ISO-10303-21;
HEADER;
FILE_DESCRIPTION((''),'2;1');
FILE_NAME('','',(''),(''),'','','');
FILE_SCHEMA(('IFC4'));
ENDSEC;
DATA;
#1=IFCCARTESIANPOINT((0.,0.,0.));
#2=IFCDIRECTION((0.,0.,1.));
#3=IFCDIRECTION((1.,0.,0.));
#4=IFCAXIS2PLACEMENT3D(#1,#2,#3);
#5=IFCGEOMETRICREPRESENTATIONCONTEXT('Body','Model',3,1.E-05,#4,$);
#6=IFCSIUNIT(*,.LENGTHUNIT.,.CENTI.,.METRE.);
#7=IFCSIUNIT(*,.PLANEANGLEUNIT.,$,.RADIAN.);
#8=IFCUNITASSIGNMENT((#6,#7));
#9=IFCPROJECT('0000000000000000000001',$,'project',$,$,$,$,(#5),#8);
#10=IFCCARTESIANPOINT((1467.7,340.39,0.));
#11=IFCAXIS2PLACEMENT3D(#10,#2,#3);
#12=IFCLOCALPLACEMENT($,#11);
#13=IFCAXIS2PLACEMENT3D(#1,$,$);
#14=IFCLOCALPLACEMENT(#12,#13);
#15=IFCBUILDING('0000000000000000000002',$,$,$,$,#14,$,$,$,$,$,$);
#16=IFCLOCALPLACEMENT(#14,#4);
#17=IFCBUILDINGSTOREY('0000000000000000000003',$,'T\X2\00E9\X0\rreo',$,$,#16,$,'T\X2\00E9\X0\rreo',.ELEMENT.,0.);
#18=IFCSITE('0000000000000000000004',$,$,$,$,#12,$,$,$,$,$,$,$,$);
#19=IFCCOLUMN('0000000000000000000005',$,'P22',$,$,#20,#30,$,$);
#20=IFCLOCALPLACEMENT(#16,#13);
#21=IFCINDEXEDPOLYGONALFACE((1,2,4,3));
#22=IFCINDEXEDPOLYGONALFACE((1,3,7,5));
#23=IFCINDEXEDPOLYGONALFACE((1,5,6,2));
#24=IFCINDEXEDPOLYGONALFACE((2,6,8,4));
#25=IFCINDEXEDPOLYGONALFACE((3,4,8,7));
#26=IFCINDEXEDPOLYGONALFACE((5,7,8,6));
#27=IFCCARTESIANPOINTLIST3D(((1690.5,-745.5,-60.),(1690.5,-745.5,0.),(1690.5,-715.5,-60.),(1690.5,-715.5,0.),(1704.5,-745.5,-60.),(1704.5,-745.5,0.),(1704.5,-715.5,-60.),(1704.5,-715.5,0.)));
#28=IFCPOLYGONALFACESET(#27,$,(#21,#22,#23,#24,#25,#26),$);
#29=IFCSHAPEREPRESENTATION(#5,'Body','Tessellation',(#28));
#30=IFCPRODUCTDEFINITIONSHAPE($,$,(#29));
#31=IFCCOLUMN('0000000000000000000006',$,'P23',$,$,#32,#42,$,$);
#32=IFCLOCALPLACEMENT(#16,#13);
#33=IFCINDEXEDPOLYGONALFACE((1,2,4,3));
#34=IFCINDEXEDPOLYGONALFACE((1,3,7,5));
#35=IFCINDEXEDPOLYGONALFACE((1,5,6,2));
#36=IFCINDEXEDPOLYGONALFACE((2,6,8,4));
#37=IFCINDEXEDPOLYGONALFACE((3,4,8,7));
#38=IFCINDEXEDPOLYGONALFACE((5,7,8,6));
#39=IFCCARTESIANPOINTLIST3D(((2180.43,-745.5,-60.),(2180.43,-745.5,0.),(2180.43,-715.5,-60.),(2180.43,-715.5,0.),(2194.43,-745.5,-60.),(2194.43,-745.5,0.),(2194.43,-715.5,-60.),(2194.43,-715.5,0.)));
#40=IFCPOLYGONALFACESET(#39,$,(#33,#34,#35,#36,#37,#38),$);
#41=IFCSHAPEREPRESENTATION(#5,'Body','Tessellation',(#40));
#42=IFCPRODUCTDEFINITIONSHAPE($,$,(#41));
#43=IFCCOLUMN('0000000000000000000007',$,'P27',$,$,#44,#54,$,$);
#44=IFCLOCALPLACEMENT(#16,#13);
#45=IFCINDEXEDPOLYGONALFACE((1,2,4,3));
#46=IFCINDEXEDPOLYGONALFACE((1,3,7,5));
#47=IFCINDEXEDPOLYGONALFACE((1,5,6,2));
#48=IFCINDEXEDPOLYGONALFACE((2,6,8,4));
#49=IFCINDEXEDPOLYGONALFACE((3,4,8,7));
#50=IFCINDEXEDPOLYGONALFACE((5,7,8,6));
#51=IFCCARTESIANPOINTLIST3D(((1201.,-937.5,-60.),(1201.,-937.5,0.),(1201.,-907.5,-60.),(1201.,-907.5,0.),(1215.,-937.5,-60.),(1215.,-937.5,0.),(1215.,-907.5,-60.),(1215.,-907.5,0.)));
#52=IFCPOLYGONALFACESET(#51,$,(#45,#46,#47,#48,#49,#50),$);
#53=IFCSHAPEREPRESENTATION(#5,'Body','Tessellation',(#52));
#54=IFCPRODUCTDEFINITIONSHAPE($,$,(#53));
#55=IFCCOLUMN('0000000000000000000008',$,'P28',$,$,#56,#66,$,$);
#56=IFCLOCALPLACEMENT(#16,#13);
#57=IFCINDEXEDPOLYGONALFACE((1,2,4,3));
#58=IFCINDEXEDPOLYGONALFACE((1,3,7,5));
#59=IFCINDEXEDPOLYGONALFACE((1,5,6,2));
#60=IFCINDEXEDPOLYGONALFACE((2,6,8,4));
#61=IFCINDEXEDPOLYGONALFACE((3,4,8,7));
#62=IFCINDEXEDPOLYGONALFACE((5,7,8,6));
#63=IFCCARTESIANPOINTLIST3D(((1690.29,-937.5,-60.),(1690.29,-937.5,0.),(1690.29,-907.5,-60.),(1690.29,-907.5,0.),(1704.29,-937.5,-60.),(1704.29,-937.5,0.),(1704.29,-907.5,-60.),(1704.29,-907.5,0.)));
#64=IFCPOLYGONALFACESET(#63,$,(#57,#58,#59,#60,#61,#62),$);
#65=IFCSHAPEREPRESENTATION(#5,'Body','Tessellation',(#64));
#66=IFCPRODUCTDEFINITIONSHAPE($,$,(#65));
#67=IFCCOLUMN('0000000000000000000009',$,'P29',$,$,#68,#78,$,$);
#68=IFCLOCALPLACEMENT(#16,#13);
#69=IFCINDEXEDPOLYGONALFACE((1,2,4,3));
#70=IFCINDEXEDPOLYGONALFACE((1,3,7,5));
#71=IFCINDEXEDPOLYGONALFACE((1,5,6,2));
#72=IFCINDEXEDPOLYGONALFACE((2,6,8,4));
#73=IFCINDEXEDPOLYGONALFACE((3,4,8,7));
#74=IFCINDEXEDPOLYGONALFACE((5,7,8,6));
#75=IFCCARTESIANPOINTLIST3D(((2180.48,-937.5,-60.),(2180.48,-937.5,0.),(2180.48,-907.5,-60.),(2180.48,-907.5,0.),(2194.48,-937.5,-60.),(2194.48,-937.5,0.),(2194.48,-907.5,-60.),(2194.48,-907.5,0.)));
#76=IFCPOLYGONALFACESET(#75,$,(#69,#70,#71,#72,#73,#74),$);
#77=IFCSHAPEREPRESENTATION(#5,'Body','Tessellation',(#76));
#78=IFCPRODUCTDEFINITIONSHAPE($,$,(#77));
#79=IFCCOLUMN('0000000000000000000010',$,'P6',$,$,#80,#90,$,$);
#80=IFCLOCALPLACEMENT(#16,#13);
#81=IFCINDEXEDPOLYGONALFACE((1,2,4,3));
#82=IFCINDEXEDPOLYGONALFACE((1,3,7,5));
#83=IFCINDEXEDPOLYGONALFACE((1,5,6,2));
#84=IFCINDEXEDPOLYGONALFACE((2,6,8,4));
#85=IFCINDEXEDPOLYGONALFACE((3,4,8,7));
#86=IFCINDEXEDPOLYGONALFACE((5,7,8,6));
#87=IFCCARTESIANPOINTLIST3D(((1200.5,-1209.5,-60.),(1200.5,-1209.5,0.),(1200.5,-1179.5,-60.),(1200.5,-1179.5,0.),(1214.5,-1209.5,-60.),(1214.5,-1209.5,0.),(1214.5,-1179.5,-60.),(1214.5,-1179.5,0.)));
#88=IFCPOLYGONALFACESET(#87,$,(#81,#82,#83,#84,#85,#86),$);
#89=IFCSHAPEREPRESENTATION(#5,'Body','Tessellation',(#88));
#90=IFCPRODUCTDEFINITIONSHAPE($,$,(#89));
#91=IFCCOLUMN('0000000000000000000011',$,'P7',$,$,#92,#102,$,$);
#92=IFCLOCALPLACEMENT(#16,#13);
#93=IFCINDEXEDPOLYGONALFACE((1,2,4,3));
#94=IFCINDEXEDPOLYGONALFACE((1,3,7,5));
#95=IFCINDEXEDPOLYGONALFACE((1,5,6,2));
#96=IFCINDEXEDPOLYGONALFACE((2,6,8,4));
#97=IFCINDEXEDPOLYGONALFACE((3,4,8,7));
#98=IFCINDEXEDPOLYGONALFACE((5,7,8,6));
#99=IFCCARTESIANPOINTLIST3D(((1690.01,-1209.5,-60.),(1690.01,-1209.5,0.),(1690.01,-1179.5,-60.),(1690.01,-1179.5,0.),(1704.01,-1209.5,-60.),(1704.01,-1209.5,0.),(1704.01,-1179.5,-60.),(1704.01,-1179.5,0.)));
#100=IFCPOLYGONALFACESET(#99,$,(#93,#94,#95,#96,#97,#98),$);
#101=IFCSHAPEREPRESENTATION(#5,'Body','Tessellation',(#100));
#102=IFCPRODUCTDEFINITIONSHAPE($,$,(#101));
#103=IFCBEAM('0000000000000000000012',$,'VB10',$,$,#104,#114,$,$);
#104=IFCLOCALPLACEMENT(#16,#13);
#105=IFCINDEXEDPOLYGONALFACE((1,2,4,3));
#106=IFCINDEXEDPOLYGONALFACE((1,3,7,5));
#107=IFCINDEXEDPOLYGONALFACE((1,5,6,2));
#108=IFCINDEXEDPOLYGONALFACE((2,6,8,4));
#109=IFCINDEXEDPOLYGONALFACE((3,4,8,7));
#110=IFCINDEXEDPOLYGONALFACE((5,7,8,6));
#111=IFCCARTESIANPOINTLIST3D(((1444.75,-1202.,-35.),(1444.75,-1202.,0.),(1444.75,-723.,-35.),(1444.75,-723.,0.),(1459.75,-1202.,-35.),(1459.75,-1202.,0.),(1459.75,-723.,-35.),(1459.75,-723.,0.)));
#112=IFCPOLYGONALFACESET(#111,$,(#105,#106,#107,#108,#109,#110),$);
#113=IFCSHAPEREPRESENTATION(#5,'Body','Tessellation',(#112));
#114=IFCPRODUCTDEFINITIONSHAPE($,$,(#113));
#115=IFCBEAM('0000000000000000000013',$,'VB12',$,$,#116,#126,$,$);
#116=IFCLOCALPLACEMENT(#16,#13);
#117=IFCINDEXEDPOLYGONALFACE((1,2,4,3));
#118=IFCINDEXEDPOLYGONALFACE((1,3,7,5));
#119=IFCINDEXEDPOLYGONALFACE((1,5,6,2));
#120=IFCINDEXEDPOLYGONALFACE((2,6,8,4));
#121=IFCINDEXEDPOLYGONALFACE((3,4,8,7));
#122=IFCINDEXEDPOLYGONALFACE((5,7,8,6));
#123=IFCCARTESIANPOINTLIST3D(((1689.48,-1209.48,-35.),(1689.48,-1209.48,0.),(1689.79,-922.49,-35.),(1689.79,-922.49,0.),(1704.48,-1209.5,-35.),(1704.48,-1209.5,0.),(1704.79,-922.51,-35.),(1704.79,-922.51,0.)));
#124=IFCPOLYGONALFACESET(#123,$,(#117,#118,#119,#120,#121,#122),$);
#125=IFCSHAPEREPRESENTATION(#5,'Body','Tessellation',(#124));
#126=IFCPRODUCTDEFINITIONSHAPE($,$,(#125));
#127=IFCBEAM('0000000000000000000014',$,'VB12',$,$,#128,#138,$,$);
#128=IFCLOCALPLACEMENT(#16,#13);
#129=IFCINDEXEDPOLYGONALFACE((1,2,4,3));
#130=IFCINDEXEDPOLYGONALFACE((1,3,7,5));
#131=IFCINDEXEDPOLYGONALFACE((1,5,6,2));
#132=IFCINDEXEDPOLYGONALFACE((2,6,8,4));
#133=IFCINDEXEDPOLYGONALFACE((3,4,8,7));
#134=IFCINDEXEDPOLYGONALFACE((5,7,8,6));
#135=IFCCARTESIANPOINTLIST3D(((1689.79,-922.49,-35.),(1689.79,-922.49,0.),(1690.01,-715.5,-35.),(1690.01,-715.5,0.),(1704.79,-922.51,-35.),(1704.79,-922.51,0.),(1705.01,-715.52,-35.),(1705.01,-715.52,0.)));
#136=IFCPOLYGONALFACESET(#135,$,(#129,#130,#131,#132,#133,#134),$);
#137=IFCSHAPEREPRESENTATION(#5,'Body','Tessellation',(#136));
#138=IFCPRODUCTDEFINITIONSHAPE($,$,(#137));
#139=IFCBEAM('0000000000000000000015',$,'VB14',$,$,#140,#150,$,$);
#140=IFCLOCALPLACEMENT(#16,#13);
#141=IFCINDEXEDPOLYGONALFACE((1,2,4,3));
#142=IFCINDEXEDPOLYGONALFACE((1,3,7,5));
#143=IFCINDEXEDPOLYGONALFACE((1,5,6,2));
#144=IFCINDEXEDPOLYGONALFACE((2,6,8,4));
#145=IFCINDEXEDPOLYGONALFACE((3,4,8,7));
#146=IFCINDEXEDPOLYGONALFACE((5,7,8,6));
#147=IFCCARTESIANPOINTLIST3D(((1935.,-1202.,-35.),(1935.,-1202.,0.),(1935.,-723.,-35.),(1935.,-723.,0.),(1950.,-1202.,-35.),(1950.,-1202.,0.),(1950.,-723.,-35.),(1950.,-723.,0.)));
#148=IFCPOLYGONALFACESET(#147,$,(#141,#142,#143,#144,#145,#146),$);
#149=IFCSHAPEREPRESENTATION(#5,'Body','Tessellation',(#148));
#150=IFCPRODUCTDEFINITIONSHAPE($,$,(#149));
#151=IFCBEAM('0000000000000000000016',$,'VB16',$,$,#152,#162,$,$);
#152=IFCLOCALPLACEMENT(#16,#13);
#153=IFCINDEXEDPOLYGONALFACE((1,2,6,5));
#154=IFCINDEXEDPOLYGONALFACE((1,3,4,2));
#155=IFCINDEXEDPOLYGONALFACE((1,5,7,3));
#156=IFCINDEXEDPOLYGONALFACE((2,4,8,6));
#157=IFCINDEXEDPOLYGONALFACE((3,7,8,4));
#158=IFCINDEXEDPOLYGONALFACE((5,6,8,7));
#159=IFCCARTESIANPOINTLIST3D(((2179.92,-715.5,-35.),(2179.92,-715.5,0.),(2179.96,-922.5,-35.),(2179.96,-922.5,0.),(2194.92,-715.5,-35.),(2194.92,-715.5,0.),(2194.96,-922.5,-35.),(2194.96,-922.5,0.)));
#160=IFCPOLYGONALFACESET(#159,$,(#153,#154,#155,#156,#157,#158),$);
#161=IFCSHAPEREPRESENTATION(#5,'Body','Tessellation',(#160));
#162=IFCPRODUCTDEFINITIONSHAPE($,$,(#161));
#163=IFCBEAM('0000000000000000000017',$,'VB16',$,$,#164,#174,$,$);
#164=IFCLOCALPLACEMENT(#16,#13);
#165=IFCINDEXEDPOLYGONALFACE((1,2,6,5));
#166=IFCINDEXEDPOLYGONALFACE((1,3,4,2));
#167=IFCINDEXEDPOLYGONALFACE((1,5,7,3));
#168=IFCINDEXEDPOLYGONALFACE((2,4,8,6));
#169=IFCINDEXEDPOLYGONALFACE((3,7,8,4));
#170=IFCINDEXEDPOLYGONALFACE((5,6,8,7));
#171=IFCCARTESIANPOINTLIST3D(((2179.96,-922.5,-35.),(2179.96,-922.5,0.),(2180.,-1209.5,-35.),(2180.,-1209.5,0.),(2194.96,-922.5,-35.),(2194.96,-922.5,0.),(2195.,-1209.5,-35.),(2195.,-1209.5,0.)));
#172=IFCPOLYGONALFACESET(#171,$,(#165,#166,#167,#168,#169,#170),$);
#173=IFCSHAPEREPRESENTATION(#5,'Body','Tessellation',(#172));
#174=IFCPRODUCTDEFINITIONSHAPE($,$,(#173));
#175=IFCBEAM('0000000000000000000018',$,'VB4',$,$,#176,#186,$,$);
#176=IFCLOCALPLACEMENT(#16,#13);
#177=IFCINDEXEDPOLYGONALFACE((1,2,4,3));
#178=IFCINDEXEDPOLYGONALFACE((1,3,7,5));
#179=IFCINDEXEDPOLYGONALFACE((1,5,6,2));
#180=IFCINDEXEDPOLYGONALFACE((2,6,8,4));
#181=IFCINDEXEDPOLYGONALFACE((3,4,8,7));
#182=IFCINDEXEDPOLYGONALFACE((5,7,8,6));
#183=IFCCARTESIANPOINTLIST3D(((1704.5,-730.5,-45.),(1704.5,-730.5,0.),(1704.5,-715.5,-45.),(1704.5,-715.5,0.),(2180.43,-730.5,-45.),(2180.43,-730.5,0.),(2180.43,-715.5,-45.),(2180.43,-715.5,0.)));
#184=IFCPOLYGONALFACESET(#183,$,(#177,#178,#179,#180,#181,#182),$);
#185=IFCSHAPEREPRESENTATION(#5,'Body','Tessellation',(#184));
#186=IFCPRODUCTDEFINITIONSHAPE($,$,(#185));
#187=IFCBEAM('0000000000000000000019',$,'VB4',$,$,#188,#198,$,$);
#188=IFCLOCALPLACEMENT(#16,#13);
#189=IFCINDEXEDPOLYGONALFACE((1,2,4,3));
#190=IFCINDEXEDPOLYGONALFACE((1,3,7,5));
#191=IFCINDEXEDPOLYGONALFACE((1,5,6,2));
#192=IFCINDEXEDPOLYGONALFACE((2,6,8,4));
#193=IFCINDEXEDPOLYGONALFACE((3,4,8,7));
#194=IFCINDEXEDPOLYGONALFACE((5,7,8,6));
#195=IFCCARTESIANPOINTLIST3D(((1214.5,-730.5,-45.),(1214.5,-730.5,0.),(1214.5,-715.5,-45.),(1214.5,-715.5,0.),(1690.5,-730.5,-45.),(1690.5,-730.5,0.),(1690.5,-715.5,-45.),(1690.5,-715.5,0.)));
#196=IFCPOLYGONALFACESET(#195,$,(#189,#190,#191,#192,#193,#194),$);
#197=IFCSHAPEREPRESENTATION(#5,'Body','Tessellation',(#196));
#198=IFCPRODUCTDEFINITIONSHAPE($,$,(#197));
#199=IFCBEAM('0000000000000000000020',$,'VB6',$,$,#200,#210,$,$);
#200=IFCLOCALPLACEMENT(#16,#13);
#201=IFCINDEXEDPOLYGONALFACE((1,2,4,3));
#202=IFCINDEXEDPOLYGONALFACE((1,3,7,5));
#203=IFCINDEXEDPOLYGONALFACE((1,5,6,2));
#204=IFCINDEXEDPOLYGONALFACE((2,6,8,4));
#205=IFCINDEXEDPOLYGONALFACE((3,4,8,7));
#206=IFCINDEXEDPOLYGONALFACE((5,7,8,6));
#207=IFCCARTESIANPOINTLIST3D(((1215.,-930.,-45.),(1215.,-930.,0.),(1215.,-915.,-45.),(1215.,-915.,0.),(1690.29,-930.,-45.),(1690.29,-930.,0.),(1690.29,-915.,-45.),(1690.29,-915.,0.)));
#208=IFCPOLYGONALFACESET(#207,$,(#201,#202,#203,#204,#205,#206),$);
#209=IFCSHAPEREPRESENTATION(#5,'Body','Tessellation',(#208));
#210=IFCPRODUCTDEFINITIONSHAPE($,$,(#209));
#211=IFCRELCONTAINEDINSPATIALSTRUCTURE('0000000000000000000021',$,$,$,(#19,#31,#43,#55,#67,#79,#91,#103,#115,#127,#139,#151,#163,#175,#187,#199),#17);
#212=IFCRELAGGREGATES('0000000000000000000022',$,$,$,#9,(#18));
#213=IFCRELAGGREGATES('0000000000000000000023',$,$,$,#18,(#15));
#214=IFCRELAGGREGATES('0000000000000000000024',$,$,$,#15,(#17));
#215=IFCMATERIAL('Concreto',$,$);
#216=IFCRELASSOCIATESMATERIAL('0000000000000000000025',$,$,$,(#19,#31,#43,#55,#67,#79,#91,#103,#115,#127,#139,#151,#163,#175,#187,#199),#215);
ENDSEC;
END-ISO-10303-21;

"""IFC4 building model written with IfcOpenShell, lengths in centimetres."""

from ifc_helpers import new_model, si_unit, frame, origin, origin_with_axes, origin_2d_with_axis, place, context, project, spatial, rectangle, extrude, material, element, save


model = new_model("IFC4")

# Units and contexts
model_context = context("Model", 3, precision=1e-05, world=origin_with_axes(), identifier="Body")
ifc_project = project(units=[si_unit("LENGTHUNIT", "METRE", prefix="CENTI"), si_unit("PLANEANGLEUNIT", "RADIAN")], contexts=[model_context])

# Site, building, storey
site_placement = place(None, frame((1467.7, 340.39, 0.0), z_axis=(0.0, 0.0, 1.0), x_axis=(1.0, 0.0, 0.0)))
site = spatial("IfcSite", under=ifc_project, at=site_placement)
building_placement = place(site_placement, origin())
building = spatial("IfcBuilding", under=site, at=building_placement)
storey_placement = place(building_placement, origin_with_axes())
storey = spatial("IfcBuildingStorey", under=building, at=storey_placement, Name="Térreo", LongName="Térreo", CompositionType="ELEMENT", Elevation=0.0)

# Columns
ifc_material = material(Name="Concreto")
column_placement = place(storey_placement, frame((1697.5, -730.5, 0.0), z_axis=(0.0, 0.0, 1.0), x_axis=(1.0, 0.0, 0.0)))
element("IfcColumn", 1, at=column_placement, inside=storey, material=ifc_material, Name="P22", context=model_context, shape_type="SolidModel", body=[
    extrude(rectangle(XDim=14.0, YDim=30.0, at=origin_2d_with_axis()), frame((0.0, 0.0, -60.0), z_axis=(0.0, 0.0, 1.0), x_axis=(-1.0, 0.0, 0.0)), (0.0, 0.0, 1.0), 60.0),
])
for number, where, z_axis, x_axis, name in (
    (2, (2187.43, -730.5, 0.0), (0.0, 0.0, 1.0), (1.0, 0.0, 0.0), "P23"),
    (3, (1208.0, -922.5, 0.0), (0.0, 0.0, 1.0), (1.0, 0.0, 0.0), "P27"),
    (4, (1697.29, -922.5, 0.0), (0.0, 0.0, 1.0), (1.0, 0.0, 0.0), "P28"),
    (5, (2187.48, -922.5, 0.0), (0.0, 0.0, 1.0), (1.0, 0.0, 0.0), "P29"),
    (6, (1207.5, -1194.5, 0.0), (0.0, 0.0, 1.0), (1.0, 0.0, 0.0), "P6"),
    (7, (1697.01, -1194.5, 0.0), (0.0, 0.0, 1.0), (1.0, 0.0, 0.0), "P7"),
):
    element("IfcColumn", number, at=place(storey_placement, frame(where, z_axis=z_axis, x_axis=x_axis)), inside=storey, material=ifc_material, Name=name, context=model_context, shape_type="SolidModel", body=[
        extrude(rectangle(XDim=14.0, YDim=30.0, at=origin_2d_with_axis()), frame((0.0, 0.0, -60.0), z_axis=(0.0, 0.0, 1.0), x_axis=(1.0, 0.0, 0.0)), (0.0, 0.0, 1.0), 60.0),
    ])

# Beams
beam_1_placement = place(storey_placement, frame((1452.25, -962.5, 0.0), z_axis=(0.0, 0.0, 1.0), x_axis=(1.0, 0.0, 0.0)))
element("IfcBeam", 8, at=beam_1_placement, inside=storey, material=ifc_material, Name="VB10", context=model_context, shape_type="SolidModel", body=[
    extrude(rectangle(XDim=15.0, YDim=35.0, at=origin_2d_with_axis()), frame((0.0, -239.5, -17.5), z_axis=(0.0, 1.0, 0.0), x_axis=(1.0, 0.0, 0.0)), (0.0, 0.0, 1.0), 479.0),
])
beam_2_placement = place(storey_placement, frame((1697.13, -1066.0, 0.0), z_axis=(0.0, 0.0, 1.0), x_axis=(1.0, 0.0, 0.0)))
element("IfcBeam", 9, at=beam_2_placement, inside=storey, material=ifc_material, Name="VB12", context=model_context, shape_type="SolidModel", body=[
    extrude(rectangle(XDim=15.0, YDim=35.0, at=origin_2d_with_axis()), frame((-0.15, -143.5, -17.5), z_axis=(0.001074, 1.0, 0.0), x_axis=(1.0, -0.001074, 0.0)), (0.0, 0.0, 1.0), 286.99),
])
beam_3_placement = place(storey_placement, frame((1697.4, -819.0, 0.0), z_axis=(0.0, 0.0, 1.0), x_axis=(1.0, 0.0, 0.0)))
element("IfcBeam", 10, at=beam_3_placement, inside=storey, material=ifc_material, Name="VB12", context=model_context, shape_type="SolidModel", body=[
    extrude(rectangle(XDim=15.0, YDim=35.0, at=origin_2d_with_axis()), frame((-0.11, -103.5, -17.5), z_axis=(0.001049, 1.0, 0.0), x_axis=(1.0, -0.001049, 0.0)), (0.0, 0.0, 1.0), 206.99),
])
beam_4_placement = place(storey_placement, frame((1942.5, -962.5, 0.0), z_axis=(0.0, 0.0, 1.0), x_axis=(1.0, 0.0, 0.0)))
element("IfcBeam", 11, at=beam_4_placement, inside=storey, material=ifc_material, Name="VB14", context=model_context, shape_type="SolidModel", body=[
    extrude(rectangle(XDim=15.0, YDim=35.0, at=origin_2d_with_axis()), frame((0.0, -239.5, -17.5), z_axis=(0.0, 1.0, 0.0), x_axis=(1.0, 0.0, 0.0)), (0.0, 0.0, 1.0), 479.0),
])
beam_5_placement = place(storey_placement, frame((2187.44, -819.0, 0.0), z_axis=(0.0, 0.0, 1.0), x_axis=(1.0, 0.0, 0.0)))
element("IfcBeam", 12, at=beam_5_placement, inside=storey, material=ifc_material, Name="VB16", context=model_context, shape_type="SolidModel", body=[
    extrude(rectangle(XDim=15.0, YDim=35.0, at=origin_2d_with_axis()), frame((0.02, -103.5, -17.5), z_axis=(-0.000185, 1.0, 0.0), x_axis=(1.0, 0.000185, 0.0)), (0.0, 0.0, 1.0), 207.0),
])
beam_6_placement = place(storey_placement, frame((2187.48, -1066.0, 0.0), z_axis=(0.0, 0.0, 1.0), x_axis=(1.0, 0.0, 0.0)))
element("IfcBeam", 13, at=beam_6_placement, inside=storey, material=ifc_material, Name="VB16", context=model_context, shape_type="SolidModel", body=[
    extrude(rectangle(XDim=15.0, YDim=35.0, at=origin_2d_with_axis()), frame((0.02, -143.5, -17.5), z_axis=(-0.000165, 1.0, 0.0), x_axis=(1.0, 0.000165, 0.0)), (0.0, 0.0, 1.0), 287.0),
])
beam_7_placement = place(storey_placement, frame((1942.46, -723.0, 0.0), z_axis=(0.0, 0.0, 1.0), x_axis=(1.0, 0.0, 0.0)))
element("IfcBeam", 14, at=beam_7_placement, inside=storey, material=ifc_material, Name="VB4", context=model_context, shape_type="SolidModel", body=[
    extrude(rectangle(XDim=15.0, YDim=45.0, at=origin_2d_with_axis()), frame((-237.97, 0.0, -22.5), z_axis=(1.0, 0.0, 0.0), x_axis=(0.0, 1.0, 0.0)), (0.0, 0.0, 1.0), 475.93),
])
beam_8_placement = place(storey_placement, frame((1452.5, -723.0, 0.0), z_axis=(0.0, 0.0, 1.0), x_axis=(1.0, 0.0, 0.0)))
element("IfcBeam", 15, at=beam_8_placement, inside=storey, material=ifc_material, Name="VB4", context=model_context, shape_type="SolidModel", body=[
    extrude(rectangle(XDim=15.0, YDim=45.0, at=origin_2d_with_axis()), frame((-238.0, 0.0, -22.5), z_axis=(1.0, 0.0, 0.0), x_axis=(0.0, 1.0, 0.0)), (0.0, 0.0, 1.0), 476.0),
])
beam_9_placement = place(storey_placement, frame((1452.64, -922.5, 0.0), z_axis=(0.0, 0.0, 1.0), x_axis=(1.0, 0.0, 0.0)))
element("IfcBeam", 16, at=beam_9_placement, inside=storey, material=ifc_material, Name="VB6", context=model_context, shape_type="SolidModel", body=[
    extrude(rectangle(XDim=15.0, YDim=45.0, at=origin_2d_with_axis()), frame((-237.65, 0.0, -22.5), z_axis=(1.0, 0.0, 0.0), x_axis=(0.0, -1.0, 0.0)), (0.0, 0.0, 1.0), 475.29),
])

save(model, "model.ifc")
